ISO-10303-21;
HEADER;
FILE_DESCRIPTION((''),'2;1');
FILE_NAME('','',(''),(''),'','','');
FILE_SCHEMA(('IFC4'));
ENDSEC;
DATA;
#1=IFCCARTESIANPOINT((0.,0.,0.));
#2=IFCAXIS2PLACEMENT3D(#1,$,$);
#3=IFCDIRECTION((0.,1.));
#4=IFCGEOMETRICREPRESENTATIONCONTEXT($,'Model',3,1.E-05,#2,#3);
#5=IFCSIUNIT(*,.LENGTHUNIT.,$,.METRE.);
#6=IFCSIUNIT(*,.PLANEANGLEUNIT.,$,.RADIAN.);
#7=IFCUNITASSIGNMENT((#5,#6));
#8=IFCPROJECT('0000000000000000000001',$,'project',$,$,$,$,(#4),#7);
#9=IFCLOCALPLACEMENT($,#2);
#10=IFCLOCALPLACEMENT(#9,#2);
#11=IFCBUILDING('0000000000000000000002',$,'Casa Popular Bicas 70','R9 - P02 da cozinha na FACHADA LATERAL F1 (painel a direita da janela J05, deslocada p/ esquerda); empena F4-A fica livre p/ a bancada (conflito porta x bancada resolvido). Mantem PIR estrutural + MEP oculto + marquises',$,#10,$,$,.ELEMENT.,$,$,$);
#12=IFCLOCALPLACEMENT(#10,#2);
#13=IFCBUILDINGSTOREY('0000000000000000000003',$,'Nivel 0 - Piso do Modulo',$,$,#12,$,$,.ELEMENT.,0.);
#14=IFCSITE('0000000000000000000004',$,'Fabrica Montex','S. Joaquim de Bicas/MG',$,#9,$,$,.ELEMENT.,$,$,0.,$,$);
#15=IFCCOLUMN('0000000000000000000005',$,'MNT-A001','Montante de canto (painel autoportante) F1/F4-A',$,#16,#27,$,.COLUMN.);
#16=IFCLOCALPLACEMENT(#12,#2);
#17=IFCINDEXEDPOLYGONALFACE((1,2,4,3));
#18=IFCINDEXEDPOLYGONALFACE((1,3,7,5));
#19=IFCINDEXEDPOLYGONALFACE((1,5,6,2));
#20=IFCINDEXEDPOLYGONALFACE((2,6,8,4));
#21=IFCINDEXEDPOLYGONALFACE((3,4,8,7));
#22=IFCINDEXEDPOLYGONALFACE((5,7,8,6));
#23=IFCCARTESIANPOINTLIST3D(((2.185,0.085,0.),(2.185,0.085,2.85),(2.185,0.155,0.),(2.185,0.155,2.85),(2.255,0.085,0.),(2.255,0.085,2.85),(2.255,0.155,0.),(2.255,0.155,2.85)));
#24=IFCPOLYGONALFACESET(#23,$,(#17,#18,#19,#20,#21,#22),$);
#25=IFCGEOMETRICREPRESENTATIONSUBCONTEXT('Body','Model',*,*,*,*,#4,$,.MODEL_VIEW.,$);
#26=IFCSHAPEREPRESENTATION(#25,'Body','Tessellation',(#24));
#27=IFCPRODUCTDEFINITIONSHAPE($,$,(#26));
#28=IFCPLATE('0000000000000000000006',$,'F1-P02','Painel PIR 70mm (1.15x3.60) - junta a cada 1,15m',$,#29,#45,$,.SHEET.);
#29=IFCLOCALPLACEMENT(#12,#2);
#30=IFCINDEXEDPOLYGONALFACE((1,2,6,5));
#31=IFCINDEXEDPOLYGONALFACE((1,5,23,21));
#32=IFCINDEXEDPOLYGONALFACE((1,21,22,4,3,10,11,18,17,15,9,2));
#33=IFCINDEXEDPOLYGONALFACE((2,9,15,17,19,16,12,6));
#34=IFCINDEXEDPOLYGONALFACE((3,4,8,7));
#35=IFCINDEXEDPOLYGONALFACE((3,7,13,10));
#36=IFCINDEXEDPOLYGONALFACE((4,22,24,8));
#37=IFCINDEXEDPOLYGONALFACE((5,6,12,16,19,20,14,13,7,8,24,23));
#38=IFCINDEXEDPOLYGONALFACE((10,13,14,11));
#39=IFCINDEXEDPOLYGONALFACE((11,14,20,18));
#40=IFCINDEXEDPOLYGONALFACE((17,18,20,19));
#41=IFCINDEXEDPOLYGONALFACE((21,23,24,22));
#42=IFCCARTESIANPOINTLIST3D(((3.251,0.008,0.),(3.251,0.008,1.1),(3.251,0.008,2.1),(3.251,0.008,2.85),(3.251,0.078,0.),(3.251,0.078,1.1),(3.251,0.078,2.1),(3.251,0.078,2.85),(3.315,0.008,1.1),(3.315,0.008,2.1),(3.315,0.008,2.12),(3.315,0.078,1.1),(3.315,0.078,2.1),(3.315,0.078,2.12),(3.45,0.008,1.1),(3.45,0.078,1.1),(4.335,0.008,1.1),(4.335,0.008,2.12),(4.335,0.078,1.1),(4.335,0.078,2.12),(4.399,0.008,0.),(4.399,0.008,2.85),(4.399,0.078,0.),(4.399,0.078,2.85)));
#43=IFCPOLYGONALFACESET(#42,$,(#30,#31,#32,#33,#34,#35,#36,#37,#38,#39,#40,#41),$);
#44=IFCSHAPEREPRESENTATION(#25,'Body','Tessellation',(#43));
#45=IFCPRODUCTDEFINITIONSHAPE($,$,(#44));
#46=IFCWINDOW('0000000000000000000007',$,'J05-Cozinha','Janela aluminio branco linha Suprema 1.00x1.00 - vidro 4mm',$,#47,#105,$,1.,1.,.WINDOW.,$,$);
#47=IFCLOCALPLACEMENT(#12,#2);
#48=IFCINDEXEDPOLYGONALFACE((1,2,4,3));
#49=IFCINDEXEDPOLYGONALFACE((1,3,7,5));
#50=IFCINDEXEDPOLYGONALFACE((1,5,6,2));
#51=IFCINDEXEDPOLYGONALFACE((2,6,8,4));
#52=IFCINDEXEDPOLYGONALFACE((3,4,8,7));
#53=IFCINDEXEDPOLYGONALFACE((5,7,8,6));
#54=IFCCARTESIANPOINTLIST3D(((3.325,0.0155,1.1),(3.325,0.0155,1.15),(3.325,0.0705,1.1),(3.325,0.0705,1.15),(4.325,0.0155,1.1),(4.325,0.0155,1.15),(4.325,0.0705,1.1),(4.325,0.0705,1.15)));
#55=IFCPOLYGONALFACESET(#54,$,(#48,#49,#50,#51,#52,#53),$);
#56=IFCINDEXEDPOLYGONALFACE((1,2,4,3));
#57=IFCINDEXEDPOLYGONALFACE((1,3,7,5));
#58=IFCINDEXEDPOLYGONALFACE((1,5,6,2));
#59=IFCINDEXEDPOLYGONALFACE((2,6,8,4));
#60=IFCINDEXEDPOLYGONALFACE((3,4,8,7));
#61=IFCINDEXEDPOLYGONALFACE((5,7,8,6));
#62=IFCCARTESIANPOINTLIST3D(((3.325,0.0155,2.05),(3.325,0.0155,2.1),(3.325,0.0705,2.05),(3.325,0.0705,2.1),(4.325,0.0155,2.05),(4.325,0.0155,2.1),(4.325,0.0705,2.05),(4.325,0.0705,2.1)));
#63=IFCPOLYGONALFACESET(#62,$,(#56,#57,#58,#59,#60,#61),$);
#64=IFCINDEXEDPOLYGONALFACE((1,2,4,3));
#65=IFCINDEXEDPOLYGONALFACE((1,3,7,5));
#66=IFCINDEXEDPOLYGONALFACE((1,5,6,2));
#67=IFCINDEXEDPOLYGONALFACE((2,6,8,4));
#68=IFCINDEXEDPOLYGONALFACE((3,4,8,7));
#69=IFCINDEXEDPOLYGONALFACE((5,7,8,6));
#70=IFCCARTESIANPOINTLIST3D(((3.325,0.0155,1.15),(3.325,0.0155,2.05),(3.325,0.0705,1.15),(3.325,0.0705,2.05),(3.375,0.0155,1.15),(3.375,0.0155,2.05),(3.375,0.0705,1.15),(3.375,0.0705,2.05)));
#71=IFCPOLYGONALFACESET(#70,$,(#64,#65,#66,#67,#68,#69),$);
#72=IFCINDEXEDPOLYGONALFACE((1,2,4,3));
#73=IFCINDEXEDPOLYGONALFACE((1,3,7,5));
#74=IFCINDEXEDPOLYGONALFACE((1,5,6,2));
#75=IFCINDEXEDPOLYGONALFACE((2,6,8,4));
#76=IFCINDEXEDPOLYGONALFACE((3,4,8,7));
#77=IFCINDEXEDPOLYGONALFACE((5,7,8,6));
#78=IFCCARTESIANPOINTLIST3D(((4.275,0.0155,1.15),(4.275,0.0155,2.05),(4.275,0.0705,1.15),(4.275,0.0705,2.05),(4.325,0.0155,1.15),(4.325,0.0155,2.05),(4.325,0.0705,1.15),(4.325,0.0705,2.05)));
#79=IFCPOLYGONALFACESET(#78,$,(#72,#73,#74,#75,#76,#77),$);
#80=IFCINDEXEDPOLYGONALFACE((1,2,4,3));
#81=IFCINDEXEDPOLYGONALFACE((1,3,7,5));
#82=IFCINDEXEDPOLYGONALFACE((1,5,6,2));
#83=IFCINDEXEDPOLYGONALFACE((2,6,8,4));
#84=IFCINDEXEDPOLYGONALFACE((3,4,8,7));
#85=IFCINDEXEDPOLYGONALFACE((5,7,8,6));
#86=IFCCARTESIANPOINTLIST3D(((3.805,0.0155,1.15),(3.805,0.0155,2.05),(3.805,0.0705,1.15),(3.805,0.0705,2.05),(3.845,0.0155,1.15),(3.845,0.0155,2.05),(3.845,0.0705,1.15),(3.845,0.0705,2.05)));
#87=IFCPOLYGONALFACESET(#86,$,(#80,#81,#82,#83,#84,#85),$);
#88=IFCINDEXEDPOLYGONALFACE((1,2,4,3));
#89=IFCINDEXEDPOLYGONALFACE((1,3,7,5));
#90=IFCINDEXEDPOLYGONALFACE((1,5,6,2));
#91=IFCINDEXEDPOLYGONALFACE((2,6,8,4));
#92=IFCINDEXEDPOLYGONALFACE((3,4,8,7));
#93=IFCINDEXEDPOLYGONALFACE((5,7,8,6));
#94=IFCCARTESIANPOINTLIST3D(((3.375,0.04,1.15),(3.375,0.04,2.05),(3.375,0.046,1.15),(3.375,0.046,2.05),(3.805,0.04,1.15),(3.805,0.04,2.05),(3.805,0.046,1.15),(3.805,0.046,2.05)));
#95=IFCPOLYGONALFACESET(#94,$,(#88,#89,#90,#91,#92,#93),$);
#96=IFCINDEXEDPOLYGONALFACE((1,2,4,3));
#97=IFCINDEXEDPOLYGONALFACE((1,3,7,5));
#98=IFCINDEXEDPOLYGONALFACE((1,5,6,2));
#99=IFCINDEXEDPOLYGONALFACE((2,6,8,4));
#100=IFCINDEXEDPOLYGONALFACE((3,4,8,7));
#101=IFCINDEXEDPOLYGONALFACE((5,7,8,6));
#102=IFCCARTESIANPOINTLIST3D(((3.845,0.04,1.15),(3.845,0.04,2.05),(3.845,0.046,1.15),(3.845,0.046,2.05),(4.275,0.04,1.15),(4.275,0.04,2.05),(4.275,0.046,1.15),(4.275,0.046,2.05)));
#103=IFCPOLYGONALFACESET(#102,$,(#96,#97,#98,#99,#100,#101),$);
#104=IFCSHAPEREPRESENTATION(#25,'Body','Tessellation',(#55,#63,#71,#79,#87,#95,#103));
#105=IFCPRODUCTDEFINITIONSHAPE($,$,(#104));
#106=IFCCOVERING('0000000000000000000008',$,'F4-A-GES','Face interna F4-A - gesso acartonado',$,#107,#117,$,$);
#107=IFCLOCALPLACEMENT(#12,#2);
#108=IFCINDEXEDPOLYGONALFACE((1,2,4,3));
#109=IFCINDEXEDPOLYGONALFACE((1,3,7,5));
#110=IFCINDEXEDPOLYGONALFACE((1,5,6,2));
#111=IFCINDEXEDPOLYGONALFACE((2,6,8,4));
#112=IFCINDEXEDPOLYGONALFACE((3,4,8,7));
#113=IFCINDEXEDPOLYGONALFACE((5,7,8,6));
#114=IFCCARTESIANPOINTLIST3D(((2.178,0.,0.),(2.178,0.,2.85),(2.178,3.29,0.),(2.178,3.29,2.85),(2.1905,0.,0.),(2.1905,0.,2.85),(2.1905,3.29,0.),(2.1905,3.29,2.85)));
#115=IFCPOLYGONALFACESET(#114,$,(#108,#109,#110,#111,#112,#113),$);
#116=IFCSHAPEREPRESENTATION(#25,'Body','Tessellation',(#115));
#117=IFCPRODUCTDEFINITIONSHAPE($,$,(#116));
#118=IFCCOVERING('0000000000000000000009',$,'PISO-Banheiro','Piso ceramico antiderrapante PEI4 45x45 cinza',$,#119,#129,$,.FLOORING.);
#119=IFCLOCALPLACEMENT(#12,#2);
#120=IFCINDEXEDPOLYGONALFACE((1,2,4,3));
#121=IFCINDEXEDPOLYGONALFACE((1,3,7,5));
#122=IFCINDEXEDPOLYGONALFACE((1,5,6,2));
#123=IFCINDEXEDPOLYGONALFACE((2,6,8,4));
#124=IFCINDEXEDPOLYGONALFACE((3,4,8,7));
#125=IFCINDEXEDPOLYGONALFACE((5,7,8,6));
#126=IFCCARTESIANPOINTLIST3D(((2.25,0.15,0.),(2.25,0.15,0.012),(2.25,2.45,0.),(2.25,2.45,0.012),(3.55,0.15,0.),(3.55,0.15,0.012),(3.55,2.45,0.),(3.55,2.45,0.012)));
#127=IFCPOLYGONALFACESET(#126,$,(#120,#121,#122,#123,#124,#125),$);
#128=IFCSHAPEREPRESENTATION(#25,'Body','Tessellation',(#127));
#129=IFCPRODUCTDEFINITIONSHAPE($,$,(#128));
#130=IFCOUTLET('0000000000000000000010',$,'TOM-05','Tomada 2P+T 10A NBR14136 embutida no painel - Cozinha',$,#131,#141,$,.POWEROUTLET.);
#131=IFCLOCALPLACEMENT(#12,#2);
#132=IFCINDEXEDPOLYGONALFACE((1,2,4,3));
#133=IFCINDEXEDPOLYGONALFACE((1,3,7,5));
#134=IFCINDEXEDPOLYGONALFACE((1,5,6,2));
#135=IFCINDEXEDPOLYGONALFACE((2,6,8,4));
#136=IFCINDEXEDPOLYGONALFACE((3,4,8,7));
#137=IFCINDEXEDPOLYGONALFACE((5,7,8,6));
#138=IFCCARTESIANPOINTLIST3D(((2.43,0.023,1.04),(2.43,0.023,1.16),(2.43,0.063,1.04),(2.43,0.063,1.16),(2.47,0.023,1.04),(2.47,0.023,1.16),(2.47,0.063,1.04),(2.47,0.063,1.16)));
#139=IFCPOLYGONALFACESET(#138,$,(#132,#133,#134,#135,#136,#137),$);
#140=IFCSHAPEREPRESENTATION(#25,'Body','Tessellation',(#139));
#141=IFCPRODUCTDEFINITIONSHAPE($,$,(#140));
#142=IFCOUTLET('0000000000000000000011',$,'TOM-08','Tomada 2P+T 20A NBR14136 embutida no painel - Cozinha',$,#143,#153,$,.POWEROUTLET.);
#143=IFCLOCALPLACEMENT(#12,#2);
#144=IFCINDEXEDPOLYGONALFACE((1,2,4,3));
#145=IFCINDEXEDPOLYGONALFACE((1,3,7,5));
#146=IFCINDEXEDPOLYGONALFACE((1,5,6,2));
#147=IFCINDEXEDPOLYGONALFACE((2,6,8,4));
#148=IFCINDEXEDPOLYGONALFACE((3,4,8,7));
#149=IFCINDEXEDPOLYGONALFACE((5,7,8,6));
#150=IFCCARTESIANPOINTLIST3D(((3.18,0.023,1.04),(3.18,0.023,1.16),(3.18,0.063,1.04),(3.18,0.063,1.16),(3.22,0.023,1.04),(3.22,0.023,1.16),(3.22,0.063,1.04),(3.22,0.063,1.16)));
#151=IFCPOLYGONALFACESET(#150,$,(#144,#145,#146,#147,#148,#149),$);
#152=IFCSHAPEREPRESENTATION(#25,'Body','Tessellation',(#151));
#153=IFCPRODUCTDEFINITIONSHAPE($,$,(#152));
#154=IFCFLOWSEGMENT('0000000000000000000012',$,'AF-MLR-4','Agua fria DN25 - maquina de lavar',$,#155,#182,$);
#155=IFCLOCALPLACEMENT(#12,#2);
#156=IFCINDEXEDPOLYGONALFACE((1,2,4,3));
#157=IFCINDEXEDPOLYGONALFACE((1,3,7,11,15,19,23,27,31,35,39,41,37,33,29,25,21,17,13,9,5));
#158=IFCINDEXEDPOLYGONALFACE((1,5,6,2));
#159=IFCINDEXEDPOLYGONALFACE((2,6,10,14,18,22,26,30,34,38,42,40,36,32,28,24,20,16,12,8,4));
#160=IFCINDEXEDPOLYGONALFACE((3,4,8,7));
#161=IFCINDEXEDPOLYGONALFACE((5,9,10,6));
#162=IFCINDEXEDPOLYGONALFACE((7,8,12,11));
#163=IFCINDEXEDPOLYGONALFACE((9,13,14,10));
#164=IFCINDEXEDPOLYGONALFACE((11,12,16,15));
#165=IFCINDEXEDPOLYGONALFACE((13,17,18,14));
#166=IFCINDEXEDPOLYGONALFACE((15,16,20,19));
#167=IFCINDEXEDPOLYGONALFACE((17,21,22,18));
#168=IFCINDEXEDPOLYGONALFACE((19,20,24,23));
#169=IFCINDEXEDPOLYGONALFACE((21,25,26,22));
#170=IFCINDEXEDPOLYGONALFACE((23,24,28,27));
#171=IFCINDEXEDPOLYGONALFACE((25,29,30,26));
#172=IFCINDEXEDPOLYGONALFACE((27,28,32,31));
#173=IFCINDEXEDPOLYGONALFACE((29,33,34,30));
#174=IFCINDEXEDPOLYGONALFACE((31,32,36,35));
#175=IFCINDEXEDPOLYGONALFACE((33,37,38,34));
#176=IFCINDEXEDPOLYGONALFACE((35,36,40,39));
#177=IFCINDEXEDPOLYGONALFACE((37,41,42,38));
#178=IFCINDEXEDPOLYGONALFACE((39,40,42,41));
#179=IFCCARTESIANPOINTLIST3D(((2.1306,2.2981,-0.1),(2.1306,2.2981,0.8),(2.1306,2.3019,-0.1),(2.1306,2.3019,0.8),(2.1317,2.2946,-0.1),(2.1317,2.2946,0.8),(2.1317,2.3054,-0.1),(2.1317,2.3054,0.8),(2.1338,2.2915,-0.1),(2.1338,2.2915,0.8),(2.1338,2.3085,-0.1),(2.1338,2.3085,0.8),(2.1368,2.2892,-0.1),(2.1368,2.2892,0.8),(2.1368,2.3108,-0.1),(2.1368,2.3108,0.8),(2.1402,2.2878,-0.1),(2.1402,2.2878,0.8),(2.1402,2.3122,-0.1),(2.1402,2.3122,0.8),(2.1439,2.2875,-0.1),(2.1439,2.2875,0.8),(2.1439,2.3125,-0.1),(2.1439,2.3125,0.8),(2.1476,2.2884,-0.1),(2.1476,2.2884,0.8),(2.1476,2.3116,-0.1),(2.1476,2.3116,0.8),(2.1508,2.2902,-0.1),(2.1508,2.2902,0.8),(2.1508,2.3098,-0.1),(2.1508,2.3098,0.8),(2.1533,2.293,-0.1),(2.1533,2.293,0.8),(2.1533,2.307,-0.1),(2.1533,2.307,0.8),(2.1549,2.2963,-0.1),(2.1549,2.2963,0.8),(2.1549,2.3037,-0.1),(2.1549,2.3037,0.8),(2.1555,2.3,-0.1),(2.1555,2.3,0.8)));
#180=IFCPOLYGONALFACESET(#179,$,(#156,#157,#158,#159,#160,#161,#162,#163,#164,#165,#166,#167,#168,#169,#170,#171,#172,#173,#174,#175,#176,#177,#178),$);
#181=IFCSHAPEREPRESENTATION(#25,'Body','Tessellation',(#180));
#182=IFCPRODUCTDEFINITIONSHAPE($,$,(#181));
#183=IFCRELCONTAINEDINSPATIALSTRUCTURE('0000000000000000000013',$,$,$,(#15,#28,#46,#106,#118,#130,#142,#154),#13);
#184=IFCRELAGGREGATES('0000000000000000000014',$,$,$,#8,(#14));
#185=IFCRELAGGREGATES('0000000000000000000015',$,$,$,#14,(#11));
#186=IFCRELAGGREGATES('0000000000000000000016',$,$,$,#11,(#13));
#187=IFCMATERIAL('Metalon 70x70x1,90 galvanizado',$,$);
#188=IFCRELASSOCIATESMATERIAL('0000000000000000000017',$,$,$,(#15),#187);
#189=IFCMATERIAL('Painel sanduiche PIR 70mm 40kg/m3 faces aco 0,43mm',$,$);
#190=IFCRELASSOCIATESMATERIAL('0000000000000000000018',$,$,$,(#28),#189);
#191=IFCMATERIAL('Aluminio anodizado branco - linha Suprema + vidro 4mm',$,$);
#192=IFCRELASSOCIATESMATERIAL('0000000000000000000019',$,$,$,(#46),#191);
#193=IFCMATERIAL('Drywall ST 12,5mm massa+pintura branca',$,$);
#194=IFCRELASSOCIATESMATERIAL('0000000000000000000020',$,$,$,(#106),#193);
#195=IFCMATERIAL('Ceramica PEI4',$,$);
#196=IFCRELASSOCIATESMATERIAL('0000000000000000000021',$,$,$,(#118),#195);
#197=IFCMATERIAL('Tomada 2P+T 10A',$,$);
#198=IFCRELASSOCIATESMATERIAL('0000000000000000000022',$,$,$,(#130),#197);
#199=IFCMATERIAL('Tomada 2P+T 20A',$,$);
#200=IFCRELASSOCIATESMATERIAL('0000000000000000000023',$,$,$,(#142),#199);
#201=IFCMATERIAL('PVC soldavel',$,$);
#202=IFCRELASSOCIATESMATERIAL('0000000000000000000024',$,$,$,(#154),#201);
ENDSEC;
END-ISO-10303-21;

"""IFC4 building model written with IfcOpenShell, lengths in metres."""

from ifc_helpers import new_model, si_unit, direction, frame, frame_2d, origin, origin_2d, place, context, subcontext, project, spatial, rectangle, circle, extrude, material, element, fill, save


model = new_model("IFC4")

# Units and contexts
model_context = context("Model", 3, precision=1e-05, world=origin(), true_north=direction((0.0, 1.0)))
body_context = subcontext(model_context, "Body", "Model", "MODEL_VIEW")
ifc_project = project(units=[si_unit("LENGTHUNIT", "METRE"), si_unit("PLANEANGLEUNIT", "RADIAN")], contexts=[model_context])

# Site, building, storey
site_placement = place(None, origin())
site = spatial("IfcSite", under=ifc_project, at=site_placement, Name="Fabrica Montex", Description="S. Joaquim de Bicas/MG", CompositionType="ELEMENT", RefElevation=0.0)
building_placement = place(site_placement, origin())
building = spatial("IfcBuilding", under=site, at=building_placement, Name="Casa Popular Bicas 70", Description="R9 - P02 da cozinha na FACHADA LATERAL F1 (painel a direita da janela J05, deslocada p/ esquerda); empena F4-A fica livre p/ a bancada (conflito porta x bancada resolvido). Mantem PIR estrutural + MEP oculto + marquises", CompositionType="ELEMENT")
storey_placement = place(building_placement, origin())
storey = spatial("IfcBuildingStorey", under=building, at=storey_placement, Name="Nivel 0 - Piso do Modulo", CompositionType="ELEMENT", Elevation=0.0)

# Column
ifc_material_1 = material(Name="Metalon 70x70x1,90 galvanizado")
column_placement = place(storey_placement, frame((2.22, 0.12, 0.0)))
element("IfcColumn", 1, at=column_placement, inside=storey, material=ifc_material_1, Name="MNT-A001", Description="Montante de canto (painel autoportante) F1/F4-A", PredefinedType="COLUMN", context=body_context, shape_type="SweptSolid", body=[
    extrude(rectangle(XDim=0.07, YDim=0.07, at=origin_2d()), origin(), (0.0, 0.0, 1.0), 2.85),
])

# Plate, openings, window
ifc_material_2 = material(Name="Painel sanduiche PIR 70mm 40kg/m3 faces aco 0,43mm")
plate_placement = place(storey_placement, frame((3.251, 0.043, 0.0), x_axis=(1.0, 0.0, 0.0)))
plate = element("IfcPlate", 2, at=plate_placement, inside=storey, material=ifc_material_2, Name="F1-P02", Description="Painel PIR 70mm (1.15x3.60) - junta a cada 1,15m", PredefinedType="SHEET", context=body_context, shape_type="SweptSolid", body=[
    extrude(rectangle(XDim=1.148, YDim=0.07, at=frame_2d((0.574, 0.0))), origin(), (0.0, 0.0, 1.0), 2.85),
])
opening_1_placement = place(storey_placement, frame((3.325, 0.043, 1.1)))
opening_1 = element("IfcOpeningElement", 3, at=opening_1_placement, cuts=plate, PredefinedType="OPENING", context=body_context, shape_type="SweptSolid", body=[
    extrude(rectangle(XDim=1.02, YDim=0.3, at=frame_2d((0.5, 0.0))), origin(), (0.0, 0.0, 1.0), 1.02),
])
opening_2_placement = place(storey_placement, frame((3.35, 0.043, 1.1)))
element("IfcOpeningElement", 4, at=opening_2_placement, cuts=plate, PredefinedType="OPENING", context=body_context, shape_type="SweptSolid", body=[
    extrude(rectangle(XDim=0.2, YDim=0.1, at=origin_2d()), origin(), (0.0, 0.0, 1.0), 1.0),
])
ifc_material_3 = material(Name="Aluminio anodizado branco - linha Suprema + vidro 4mm")
window_placement = place(storey_placement, frame((3.325, 0.043, 1.1), x_axis=(1.0, 0.0, 0.0)))
window = element("IfcWindow", 5, at=window_placement, inside=storey, material=ifc_material_3, Name="J05-Cozinha", Description="Janela aluminio branco linha Suprema 1.00x1.00 - vidro 4mm", OverallHeight=1.0, OverallWidth=1.0, PredefinedType="WINDOW", context=body_context, shape_type="SweptSolid", body=[
    extrude(rectangle(XDim=1.0, YDim=0.055, at=frame_2d((0.5, 0.0))), origin(), (0.0, 0.0, 1.0), 0.05),
    extrude(rectangle(XDim=1.0, YDim=0.055, at=frame_2d((0.5, 0.0))), frame((0.0, 0.0, 0.95)), (0.0, 0.0, 1.0), 0.05),
    extrude(rectangle(XDim=0.05, YDim=0.055, at=frame_2d((0.025, 0.0))), frame((0.0, 0.0, 0.05)), (0.0, 0.0, 1.0), 0.9),
    extrude(rectangle(XDim=0.05, YDim=0.055, at=frame_2d((0.975, 0.0))), frame((0.0, 0.0, 0.05)), (0.0, 0.0, 1.0), 0.9),
    extrude(rectangle(XDim=0.04, YDim=0.055, at=frame_2d((0.5, 0.0))), frame((0.0, 0.0, 0.05)), (0.0, 0.0, 1.0), 0.9),
    extrude(rectangle(XDim=0.43, YDim=0.006, at=frame_2d((0.265, 0.0))), frame((0.0, 0.0, 0.05)), (0.0, 0.0, 1.0), 0.9),
    extrude(rectangle(XDim=0.43, YDim=0.006, at=frame_2d((0.735, 0.0))), frame((0.0, 0.0, 0.05)), (0.0, 0.0, 1.0), 0.9),
])
fill(opening_1, window)

# Coverings
ifc_material_4 = material(Name="Drywall ST 12,5mm massa+pintura branca")
covering_1_placement = place(storey_placement, frame((2.1843, 0.0, 0.0), x_axis=(0.0, 1.0, 0.0)))
element("IfcCovering", 6, at=covering_1_placement, inside=storey, material=ifc_material_4, Name="F4-A-GES", Description="Face interna F4-A - gesso acartonado", context=body_context, shape_type="SweptSolid", body=[
    extrude(rectangle(XDim=3.29, YDim=0.0125, at=frame_2d((1.645, 0.0))), origin(), (0.0, 0.0, 1.0), 2.85),
])
ifc_material_5 = material(Name="Ceramica PEI4")
covering_2_placement = place(storey_placement, frame((2.25, 0.15, 0.0)))
element("IfcCovering", 7, at=covering_2_placement, inside=storey, material=ifc_material_5, Name="PISO-Banheiro", Description="Piso ceramico antiderrapante PEI4 45x45 cinza", PredefinedType="FLOORING", context=body_context, shape_type="SweptSolid", body=[
    extrude(rectangle(XDim=1.3, YDim=2.3, at=frame_2d((0.65, 1.15))), origin(), (0.0, 0.0, 1.0), 0.012),
])

# Outlets
ifc_material_6 = material(Name="Tomada 2P+T 10A")
outlet_1_placement = place(storey_placement, frame((2.43, 0.023, 1.04)))
element("IfcOutlet", 8, at=outlet_1_placement, inside=storey, material=ifc_material_6, Name="TOM-05", Description="Tomada 2P+T 10A NBR14136 embutida no painel - Cozinha", PredefinedType="POWEROUTLET", context=body_context, shape_type="SweptSolid", body=[
    extrude(rectangle(XDim=0.04, YDim=0.04, at=frame_2d((0.02, 0.02))), origin(), (0.0, 0.0, 1.0), 0.12),
])
ifc_material_7 = material(Name="Tomada 2P+T 20A")
outlet_2_placement = place(storey_placement, frame((3.18, 0.023, 1.04)))
element("IfcOutlet", 9, at=outlet_2_placement, inside=storey, material=ifc_material_7, Name="TOM-08", Description="Tomada 2P+T 20A NBR14136 embutida no painel - Cozinha", PredefinedType="POWEROUTLET", context=body_context, shape_type="SweptSolid", body=[
    extrude(rectangle(XDim=0.04, YDim=0.04, at=frame_2d((0.02, 0.02))), origin(), (0.0, 0.0, 1.0), 0.12),
])

# Flow segment
ifc_material_8 = material(Name="PVC soldavel")
flow_segment_1_placement = place(storey_placement, frame((2.143, 2.3, -0.1), z_axis=(0.0, 0.0, 1.0), x_axis=(1.0, 0.0, 0.0)))
element("IfcFlowSegment", 10, at=flow_segment_1_placement, inside=storey, material=ifc_material_8, Name="AF-MLR-4", Description="Agua fria DN25 - maquina de lavar", context=body_context, shape_type="SweptSolid", body=[
    extrude(circle(Radius=0.0125, at=origin_2d()), origin(), (0.0, 0.0, 1.0), 0.9),
])

save(model, "model.ifc")
